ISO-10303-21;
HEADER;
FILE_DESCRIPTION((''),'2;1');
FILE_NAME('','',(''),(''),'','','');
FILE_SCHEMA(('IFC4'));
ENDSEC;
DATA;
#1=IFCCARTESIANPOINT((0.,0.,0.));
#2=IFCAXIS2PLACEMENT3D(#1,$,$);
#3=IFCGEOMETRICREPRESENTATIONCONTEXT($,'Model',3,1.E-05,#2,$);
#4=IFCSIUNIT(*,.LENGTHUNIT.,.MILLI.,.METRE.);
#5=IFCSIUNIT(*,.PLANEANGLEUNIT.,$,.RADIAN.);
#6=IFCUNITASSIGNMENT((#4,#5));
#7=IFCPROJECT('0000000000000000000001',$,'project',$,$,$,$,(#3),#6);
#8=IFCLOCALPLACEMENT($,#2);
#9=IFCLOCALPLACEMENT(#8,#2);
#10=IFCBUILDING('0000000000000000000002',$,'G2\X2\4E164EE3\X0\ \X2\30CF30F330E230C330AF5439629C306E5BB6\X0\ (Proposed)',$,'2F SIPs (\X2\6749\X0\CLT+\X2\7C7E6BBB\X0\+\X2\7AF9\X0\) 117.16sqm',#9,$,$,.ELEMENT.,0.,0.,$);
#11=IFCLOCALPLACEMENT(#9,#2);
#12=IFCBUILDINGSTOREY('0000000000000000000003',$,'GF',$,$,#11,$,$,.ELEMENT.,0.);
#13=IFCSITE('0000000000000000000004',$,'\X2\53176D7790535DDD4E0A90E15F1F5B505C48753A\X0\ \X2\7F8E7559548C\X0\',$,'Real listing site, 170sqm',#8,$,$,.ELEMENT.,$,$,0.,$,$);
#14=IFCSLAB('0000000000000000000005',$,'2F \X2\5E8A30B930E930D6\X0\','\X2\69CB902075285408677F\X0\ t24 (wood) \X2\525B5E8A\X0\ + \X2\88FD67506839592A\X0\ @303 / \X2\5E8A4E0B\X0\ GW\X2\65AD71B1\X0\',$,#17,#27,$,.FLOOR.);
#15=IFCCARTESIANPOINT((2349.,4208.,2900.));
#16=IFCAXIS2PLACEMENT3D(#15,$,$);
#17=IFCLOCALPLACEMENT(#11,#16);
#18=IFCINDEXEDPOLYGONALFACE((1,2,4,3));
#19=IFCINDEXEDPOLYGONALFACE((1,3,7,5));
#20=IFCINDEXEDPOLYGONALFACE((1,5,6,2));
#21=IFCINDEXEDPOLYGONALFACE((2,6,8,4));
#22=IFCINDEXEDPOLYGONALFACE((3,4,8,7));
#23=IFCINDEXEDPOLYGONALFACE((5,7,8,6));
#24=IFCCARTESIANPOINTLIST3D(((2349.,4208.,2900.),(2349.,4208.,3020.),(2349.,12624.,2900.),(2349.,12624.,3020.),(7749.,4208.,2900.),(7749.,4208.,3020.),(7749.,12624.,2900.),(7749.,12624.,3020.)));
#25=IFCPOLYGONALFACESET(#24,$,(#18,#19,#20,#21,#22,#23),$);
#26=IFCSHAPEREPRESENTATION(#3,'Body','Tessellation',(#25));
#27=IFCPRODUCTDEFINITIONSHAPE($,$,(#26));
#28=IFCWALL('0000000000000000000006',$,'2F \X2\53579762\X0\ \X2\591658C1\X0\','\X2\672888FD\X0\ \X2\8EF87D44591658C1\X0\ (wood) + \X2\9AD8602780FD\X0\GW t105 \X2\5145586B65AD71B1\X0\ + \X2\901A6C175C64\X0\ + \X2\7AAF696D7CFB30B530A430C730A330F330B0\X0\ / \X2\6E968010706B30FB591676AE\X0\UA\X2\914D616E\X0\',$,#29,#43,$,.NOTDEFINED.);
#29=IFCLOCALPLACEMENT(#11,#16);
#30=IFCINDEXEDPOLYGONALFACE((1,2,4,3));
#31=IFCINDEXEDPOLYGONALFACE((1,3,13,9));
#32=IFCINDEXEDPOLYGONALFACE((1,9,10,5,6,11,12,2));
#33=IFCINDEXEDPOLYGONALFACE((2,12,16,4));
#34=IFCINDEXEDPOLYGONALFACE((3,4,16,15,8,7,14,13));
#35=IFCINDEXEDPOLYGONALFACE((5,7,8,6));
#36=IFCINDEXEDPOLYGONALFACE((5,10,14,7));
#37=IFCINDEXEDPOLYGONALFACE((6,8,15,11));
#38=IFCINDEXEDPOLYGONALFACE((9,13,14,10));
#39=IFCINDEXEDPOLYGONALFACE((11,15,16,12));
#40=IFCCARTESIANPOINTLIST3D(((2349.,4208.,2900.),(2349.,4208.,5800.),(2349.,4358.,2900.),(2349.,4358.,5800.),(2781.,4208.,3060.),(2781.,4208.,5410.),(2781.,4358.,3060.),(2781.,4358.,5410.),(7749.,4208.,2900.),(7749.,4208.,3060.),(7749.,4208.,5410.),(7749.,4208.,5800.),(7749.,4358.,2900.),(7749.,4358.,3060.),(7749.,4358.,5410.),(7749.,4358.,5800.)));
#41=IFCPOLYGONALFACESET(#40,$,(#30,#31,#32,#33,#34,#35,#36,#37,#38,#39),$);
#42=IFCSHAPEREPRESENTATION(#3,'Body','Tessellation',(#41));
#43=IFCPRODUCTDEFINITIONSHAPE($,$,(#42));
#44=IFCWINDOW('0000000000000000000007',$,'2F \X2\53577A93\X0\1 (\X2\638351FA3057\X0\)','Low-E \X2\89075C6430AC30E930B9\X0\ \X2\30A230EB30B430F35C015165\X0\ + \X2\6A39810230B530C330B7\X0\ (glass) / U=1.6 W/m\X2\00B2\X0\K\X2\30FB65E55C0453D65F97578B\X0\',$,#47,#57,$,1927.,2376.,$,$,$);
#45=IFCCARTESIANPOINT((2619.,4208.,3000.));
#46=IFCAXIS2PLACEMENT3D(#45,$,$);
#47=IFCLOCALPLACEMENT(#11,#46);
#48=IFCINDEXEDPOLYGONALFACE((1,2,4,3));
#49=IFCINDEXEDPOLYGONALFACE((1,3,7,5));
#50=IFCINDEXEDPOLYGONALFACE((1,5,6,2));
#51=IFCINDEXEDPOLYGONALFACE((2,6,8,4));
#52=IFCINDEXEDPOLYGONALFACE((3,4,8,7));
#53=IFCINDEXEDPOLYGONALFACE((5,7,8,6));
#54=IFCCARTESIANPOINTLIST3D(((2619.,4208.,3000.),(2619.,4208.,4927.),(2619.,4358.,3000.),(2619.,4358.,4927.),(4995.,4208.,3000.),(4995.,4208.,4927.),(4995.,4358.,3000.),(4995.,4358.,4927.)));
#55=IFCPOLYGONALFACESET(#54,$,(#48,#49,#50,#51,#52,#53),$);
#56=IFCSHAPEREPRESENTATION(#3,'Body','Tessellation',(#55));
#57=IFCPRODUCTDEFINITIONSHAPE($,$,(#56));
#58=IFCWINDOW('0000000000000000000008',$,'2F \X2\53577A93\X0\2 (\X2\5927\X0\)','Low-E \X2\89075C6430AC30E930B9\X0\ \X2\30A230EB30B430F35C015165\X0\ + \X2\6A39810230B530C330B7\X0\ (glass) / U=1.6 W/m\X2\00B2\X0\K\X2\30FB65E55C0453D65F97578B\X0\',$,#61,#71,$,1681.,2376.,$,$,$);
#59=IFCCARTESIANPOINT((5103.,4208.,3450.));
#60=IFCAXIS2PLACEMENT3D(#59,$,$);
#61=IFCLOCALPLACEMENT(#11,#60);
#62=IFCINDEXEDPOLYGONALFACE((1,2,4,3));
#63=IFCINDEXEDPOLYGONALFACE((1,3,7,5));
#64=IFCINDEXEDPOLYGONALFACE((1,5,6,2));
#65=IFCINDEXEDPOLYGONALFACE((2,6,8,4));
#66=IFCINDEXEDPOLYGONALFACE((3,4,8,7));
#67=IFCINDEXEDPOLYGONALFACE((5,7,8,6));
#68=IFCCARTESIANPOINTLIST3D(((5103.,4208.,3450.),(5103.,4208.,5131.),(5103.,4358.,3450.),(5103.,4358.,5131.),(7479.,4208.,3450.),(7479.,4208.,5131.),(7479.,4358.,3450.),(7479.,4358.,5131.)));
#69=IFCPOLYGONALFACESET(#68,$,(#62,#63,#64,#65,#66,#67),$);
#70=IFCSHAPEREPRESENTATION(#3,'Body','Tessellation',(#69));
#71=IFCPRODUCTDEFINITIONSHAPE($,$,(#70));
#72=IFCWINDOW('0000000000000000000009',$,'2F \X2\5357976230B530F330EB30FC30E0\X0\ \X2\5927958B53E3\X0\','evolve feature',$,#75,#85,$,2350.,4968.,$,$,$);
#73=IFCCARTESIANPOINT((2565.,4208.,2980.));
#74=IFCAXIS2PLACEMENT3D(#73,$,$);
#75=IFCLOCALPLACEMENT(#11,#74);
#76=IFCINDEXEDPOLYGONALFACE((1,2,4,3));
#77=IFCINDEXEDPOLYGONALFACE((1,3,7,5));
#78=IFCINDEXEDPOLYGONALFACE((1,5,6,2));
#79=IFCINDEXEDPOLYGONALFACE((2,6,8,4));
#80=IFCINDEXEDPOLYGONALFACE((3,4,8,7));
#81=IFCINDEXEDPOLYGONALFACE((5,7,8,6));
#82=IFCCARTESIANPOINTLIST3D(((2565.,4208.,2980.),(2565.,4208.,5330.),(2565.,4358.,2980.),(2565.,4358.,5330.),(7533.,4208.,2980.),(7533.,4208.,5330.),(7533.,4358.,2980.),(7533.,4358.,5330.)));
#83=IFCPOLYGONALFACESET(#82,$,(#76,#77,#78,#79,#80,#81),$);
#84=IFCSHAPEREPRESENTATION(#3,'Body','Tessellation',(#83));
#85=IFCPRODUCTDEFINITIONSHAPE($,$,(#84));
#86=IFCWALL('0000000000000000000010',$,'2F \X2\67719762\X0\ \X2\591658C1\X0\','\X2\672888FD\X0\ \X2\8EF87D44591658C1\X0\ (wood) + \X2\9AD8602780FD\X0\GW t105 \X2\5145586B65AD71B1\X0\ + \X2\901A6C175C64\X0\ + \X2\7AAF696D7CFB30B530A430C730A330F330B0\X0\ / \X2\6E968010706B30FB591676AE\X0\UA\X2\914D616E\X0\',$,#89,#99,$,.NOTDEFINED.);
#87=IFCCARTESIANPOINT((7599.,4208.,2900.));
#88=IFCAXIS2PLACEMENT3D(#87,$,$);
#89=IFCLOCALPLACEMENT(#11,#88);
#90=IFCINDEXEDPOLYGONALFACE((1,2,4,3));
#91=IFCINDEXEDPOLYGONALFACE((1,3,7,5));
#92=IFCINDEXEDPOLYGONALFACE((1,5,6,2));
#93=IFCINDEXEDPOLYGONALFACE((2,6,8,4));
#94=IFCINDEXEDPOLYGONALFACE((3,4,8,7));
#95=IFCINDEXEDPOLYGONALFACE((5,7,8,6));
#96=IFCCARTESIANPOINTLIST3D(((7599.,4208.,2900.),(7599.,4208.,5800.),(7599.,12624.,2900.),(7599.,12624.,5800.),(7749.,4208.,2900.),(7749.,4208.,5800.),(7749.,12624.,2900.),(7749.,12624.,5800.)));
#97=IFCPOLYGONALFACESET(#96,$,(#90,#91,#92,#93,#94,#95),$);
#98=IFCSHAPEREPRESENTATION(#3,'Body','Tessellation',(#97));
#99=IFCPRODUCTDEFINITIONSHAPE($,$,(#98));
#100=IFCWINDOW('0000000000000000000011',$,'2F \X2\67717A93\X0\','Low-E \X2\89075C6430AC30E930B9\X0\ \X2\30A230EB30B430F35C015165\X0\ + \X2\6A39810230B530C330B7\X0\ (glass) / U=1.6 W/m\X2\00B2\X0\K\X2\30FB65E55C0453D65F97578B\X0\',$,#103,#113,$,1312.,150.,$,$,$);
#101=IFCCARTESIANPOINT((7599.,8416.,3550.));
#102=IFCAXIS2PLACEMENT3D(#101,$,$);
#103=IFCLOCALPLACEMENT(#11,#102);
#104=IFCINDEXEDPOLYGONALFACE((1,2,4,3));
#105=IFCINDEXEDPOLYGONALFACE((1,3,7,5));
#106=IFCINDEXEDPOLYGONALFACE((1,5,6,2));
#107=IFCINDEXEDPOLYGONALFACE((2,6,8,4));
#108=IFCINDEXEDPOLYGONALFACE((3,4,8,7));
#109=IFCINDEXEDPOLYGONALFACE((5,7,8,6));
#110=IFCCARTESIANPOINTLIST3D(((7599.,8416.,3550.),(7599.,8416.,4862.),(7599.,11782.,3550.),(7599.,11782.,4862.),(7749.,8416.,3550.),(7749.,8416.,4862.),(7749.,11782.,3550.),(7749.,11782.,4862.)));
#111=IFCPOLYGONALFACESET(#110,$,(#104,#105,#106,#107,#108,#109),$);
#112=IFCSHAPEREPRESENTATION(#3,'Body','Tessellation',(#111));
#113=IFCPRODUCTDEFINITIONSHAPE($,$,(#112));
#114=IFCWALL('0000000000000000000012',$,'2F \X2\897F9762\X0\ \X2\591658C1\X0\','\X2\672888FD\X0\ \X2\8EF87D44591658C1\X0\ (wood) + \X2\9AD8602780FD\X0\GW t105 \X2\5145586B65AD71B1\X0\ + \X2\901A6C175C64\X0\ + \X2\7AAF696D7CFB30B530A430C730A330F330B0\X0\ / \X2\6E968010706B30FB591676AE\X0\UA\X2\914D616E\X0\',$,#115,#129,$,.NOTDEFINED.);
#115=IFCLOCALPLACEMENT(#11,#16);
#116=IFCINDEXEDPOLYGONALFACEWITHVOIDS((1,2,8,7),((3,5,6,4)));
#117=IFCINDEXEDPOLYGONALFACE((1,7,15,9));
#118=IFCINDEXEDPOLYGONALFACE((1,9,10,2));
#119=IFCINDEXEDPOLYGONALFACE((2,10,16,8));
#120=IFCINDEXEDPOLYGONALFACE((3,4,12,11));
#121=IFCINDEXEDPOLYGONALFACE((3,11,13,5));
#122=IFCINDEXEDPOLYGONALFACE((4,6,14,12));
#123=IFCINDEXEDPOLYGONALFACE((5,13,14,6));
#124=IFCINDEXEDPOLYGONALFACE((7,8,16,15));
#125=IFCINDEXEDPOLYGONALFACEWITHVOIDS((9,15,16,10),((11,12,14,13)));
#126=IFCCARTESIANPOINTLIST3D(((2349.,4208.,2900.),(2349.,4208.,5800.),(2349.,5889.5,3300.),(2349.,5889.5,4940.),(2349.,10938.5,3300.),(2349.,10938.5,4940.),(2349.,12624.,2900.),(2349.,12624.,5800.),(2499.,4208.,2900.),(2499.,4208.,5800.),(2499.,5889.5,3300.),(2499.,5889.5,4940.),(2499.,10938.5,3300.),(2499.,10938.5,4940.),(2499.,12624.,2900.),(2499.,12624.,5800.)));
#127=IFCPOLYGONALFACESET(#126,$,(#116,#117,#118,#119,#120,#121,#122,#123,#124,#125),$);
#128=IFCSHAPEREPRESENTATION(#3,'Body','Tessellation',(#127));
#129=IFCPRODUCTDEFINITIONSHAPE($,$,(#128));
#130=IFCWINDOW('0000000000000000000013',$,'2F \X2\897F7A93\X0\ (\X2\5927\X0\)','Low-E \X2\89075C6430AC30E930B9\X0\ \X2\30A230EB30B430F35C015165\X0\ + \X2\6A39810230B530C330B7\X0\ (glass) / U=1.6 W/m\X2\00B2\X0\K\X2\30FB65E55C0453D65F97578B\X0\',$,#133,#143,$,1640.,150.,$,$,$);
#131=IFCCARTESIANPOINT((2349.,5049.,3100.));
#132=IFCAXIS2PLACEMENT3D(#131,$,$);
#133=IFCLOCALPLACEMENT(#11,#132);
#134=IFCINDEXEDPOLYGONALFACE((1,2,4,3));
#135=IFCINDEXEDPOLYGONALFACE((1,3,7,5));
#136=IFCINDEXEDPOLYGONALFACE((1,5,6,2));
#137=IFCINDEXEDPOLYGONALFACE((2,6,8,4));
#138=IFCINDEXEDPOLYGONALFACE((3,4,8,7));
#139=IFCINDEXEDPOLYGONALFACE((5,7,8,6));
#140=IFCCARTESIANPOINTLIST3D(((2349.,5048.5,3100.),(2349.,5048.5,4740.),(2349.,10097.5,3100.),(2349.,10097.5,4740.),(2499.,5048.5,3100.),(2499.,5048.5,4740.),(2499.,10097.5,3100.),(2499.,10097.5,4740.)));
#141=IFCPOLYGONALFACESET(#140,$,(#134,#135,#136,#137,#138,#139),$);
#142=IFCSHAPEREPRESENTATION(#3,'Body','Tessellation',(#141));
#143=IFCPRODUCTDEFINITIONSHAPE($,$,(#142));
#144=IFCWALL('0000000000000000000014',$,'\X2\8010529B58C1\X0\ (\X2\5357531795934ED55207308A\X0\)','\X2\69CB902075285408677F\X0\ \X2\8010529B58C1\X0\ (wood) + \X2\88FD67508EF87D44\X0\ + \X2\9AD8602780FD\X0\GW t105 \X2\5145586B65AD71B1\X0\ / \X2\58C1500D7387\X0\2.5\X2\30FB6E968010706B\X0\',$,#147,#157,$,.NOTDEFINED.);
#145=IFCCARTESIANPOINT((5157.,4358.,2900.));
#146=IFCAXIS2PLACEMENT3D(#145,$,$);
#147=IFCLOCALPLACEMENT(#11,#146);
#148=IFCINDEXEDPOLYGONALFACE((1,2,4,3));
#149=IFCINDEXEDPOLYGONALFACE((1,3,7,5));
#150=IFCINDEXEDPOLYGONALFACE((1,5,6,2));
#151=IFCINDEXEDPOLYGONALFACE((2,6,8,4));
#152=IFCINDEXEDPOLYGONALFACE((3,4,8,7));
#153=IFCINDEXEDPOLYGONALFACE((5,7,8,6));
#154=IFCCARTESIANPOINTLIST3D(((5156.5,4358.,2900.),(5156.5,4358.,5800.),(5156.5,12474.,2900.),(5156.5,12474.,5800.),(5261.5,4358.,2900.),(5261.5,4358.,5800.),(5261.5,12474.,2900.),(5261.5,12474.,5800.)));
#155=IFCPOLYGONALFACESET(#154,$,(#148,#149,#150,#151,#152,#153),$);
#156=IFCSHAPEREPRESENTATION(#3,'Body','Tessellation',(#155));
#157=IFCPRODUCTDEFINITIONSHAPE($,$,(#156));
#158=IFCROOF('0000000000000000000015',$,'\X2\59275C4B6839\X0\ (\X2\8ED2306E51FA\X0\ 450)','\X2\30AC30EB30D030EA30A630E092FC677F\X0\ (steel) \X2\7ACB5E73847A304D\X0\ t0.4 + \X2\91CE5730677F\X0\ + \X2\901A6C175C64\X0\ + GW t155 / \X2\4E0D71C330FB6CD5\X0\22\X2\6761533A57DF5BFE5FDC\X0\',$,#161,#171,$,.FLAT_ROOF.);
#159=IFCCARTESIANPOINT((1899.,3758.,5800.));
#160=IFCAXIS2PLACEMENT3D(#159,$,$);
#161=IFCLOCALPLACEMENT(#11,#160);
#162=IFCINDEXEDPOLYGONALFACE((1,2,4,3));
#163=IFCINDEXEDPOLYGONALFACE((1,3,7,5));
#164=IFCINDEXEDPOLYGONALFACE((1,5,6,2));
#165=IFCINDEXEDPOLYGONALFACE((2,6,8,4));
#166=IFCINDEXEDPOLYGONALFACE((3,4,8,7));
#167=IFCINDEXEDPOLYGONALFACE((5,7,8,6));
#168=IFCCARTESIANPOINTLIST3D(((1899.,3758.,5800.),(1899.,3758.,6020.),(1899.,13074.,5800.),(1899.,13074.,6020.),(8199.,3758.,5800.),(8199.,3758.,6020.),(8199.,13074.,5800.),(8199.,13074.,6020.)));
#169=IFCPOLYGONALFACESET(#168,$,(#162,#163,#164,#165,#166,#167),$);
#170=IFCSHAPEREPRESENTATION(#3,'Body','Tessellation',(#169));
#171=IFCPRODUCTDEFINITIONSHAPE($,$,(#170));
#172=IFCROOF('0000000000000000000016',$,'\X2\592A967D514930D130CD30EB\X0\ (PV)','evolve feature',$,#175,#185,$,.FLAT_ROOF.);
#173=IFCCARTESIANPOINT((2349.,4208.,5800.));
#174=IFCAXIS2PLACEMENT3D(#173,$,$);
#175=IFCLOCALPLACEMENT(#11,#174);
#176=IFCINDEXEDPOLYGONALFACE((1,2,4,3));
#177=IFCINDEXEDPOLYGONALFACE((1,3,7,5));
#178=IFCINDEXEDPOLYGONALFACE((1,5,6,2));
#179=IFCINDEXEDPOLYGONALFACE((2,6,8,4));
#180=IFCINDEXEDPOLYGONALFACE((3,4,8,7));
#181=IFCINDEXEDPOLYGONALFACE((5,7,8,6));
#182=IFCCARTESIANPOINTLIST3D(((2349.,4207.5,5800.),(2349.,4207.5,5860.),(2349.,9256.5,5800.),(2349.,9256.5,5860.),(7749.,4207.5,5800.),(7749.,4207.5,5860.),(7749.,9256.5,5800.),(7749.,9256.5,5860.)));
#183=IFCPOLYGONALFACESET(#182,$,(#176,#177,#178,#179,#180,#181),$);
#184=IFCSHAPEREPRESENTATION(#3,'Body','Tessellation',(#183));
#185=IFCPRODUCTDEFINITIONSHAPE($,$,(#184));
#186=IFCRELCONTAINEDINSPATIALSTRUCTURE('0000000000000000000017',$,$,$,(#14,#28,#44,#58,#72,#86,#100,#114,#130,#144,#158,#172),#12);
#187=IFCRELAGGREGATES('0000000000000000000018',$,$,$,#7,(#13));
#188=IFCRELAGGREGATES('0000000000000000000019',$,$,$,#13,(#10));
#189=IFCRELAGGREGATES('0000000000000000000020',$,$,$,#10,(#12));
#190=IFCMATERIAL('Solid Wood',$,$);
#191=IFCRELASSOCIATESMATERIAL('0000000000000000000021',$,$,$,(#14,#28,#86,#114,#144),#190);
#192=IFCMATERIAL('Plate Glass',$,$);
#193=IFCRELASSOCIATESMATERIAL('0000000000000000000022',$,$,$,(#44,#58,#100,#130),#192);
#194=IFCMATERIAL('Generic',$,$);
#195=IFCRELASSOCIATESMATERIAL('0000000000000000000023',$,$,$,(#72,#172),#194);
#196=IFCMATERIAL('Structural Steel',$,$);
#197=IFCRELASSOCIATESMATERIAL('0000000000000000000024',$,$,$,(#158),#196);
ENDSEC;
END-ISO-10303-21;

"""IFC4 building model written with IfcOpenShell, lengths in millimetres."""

from ifc_helpers import new_model, si_unit, frame, frame_2d, origin, place, context, project, spatial, rectangle, extrude, material, element, fill, save


model = new_model("IFC4")

# Units and contexts
model_context = context("Model", 3, precision=1e-05, world=origin())
ifc_project = project(units=[si_unit("LENGTHUNIT", "METRE", prefix="MILLI"), si_unit("PLANEANGLEUNIT", "RADIAN")], contexts=[model_context])

# Site, building, storey
site_placement = place(None, origin())
site = spatial("IfcSite", under=ifc_project, at=site_placement, Name="北海道川上郡弟子屈町 美留和", ObjectType="Real listing site, 170sqm", CompositionType="ELEMENT", RefElevation=0.0)
building_placement = place(site_placement, origin())
building = spatial("IfcBuilding", under=site, at=building_placement, Name="G2世代 ハンモック吹抜の家 (Proposed)", ObjectType="2F SIPs (杉CLT+籾殻+竹) 117.16sqm", CompositionType="ELEMENT", ElevationOfRefHeight=0.0, ElevationOfTerrain=0.0)
storey_placement = place(building_placement, origin())
storey = spatial("IfcBuildingStorey", under=building, at=storey_placement, Name="GF", CompositionType="ELEMENT", Elevation=0.0)

# Slab
ifc_material_1 = material(Name="Solid Wood")
slab_placement = place(storey_placement, frame((2349.0, 4208.0, 2900.0)))
element("IfcSlab", 1, at=slab_placement, inside=storey, material=ifc_material_1, Name="2F 床スラブ", Description="構造用合板 t24 (wood) 剛床 + 製材根太 @303 / 床下 GW断熱", PredefinedType="FLOOR", context=model_context, shape_type="SweptSolid", body=[
    extrude(rectangle(XDim=5400.0, YDim=8416.0, at=frame_2d((2700.0, 4208.0))), frame((2349.0, 4208.0, 2900.0)), (0.0, 0.0, 1.0), 120.0),
])

# Wall, openings, windows
wall_1_placement = place(storey_placement, frame((2349.0, 4208.0, 2900.0)))
wall_1 = element("IfcWall", 2, at=wall_1_placement, inside=storey, material=ifc_material_1, Name="2F 南面 外壁", Description="木製 軸組外壁 (wood) + 高性能GW t105 充填断熱 + 通気層 + 窯業系サイディング / 準耐火・外皮UA配慮", PredefinedType="NOTDEFINED", context=model_context, shape_type="SweptSolid", body=[
    extrude(rectangle(XDim=5400.0, YDim=150.0, at=frame_2d((2700.0, 75.0))), frame((2349.0, 4208.0, 2900.0)), (0.0, 0.0, 1.0), 2900.0),
])
opening_1_placement = place(storey_placement, frame((2619.0, 4208.0, 3000.0)))
opening_1 = element("IfcOpeningElement", 3, at=opening_1_placement, cuts=wall_1, PredefinedType="NOTDEFINED", context=model_context, shape_type="SweptSolid", body=[
    extrude(rectangle(XDim=2376.0, YDim=150.0, at=frame_2d((1188.0, 75.0))), frame((2619.0, 4208.0, 3000.0)), (0.0, 0.0, 1.0), 1927.0),
])
opening_2_placement = place(storey_placement, frame((5103.0, 4208.0, 3450.0)))
opening_2 = element("IfcOpeningElement", 4, at=opening_2_placement, cuts=wall_1, PredefinedType="NOTDEFINED", context=model_context, shape_type="SweptSolid", body=[
    extrude(rectangle(XDim=2376.0, YDim=150.0, at=frame_2d((1188.0, 75.0))), frame((5103.0, 4208.0, 3450.0)), (0.0, 0.0, 1.0), 1681.0),
])
opening_3_placement = place(storey_placement, frame((2565.0, 4208.0, 2980.0)))
opening_3 = element("IfcOpeningElement", 5, at=opening_3_placement, cuts=wall_1, PredefinedType="NOTDEFINED", context=model_context, shape_type="SweptSolid", body=[
    extrude(rectangle(XDim=4968.0, YDim=150.0, at=frame_2d((2484.0, 75.0))), frame((2565.0, 4208.0, 2980.0)), (0.0, 0.0, 1.0), 2350.0),
])
ifc_material_2 = material(Name="Plate Glass")
window_1_placement = place(storey_placement, frame((2619.0, 4208.0, 3000.0)))
window_1 = element("IfcWindow", 6, at=window_1_placement, inside=storey, material=ifc_material_2, Name="2F 南窓1 (掃出し)", Description="Low-E 複層ガラス アルゴン封入 + 樹脂サッシ (glass) / U=1.6 W/m²K・日射取得型", OverallHeight=1927.0, OverallWidth=2376.0, context=model_context, shape_type="SweptSolid", body=[
    extrude(rectangle(XDim=2376.0, YDim=150.0, at=frame_2d((1188.0, 75.0))), frame((2619.0, 4208.0, 3000.0)), (0.0, 0.0, 1.0), 1927.0),
])
fill(opening_1, window_1)
window_2_placement = place(storey_placement, frame((5103.0, 4208.0, 3450.0)))
window_2 = element("IfcWindow", 7, at=window_2_placement, inside=storey, material=ifc_material_2, Name="2F 南窓2 (大)", Description="Low-E 複層ガラス アルゴン封入 + 樹脂サッシ (glass) / U=1.6 W/m²K・日射取得型", OverallHeight=1681.0, OverallWidth=2376.0, context=model_context, shape_type="SweptSolid", body=[
    extrude(rectangle(XDim=2376.0, YDim=150.0, at=frame_2d((1188.0, 75.0))), frame((5103.0, 4208.0, 3450.0)), (0.0, 0.0, 1.0), 1681.0),
])
fill(opening_2, window_2)
ifc_material_3 = material(Name="Generic")
window_3_placement = place(storey_placement, frame((2565.0, 4208.0, 2980.0)))
window_3 = element("IfcWindow", 8, at=window_3_placement, inside=storey, material=ifc_material_3, Name="2F 南面サンルーム 大開口", Description="evolve feature", OverallHeight=2350.0, OverallWidth=4968.0, context=model_context, shape_type="SweptSolid", body=[
    extrude(rectangle(XDim=4968.0, YDim=150.0, at=frame_2d((2484.0, 75.0))), frame((2565.0, 4208.0, 2980.0)), (0.0, 0.0, 1.0), 2350.0),
])
fill(opening_3, window_3)

# Walls, openings, windows
wall_2_placement = place(storey_placement, frame((7599.0, 4208.0, 2900.0)))
wall_2 = element("IfcWall", 9, at=wall_2_placement, inside=storey, material=ifc_material_1, Name="2F 東面 外壁", Description="木製 軸組外壁 (wood) + 高性能GW t105 充填断熱 + 通気層 + 窯業系サイディング / 準耐火・外皮UA配慮", PredefinedType="NOTDEFINED", context=model_context, shape_type="SweptSolid", body=[
    extrude(rectangle(XDim=150.0, YDim=8416.0, at=frame_2d((75.0, 4208.0))), frame((7599.0, 4208.0, 2900.0)), (0.0, 0.0, 1.0), 2900.0),
])
opening_4_placement = place(storey_placement, frame((7599.0, 8416.0, 3550.0)))
opening_4 = element("IfcOpeningElement", 10, at=opening_4_placement, cuts=wall_2, PredefinedType="NOTDEFINED", context=model_context, shape_type="SweptSolid", body=[
    extrude(rectangle(XDim=150.0, YDim=3366.0, at=frame_2d((75.0, 1683.0))), frame((7599.0, 8416.0, 3550.0)), (0.0, 0.0, 1.0), 1312.0),
])
window_4_placement = place(storey_placement, frame((7599.0, 8416.0, 3550.0)))
window_4 = element("IfcWindow", 11, at=window_4_placement, inside=storey, material=ifc_material_2, Name="2F 東窓", Description="Low-E 複層ガラス アルゴン封入 + 樹脂サッシ (glass) / U=1.6 W/m²K・日射取得型", OverallHeight=1312.0, OverallWidth=150.0, context=model_context, shape_type="SweptSolid", body=[
    extrude(rectangle(XDim=150.0, YDim=3366.0, at=frame_2d((75.0, 1683.0))), frame((7599.0, 8416.0, 3550.0)), (0.0, 0.0, 1.0), 1312.0),
])
fill(opening_4, window_4)
wall_3_placement = place(storey_placement, frame((2349.0, 4208.0, 2900.0)))
wall_3 = element("IfcWall", 12, at=wall_3_placement, inside=storey, material=ifc_material_1, Name="2F 西面 外壁", Description="木製 軸組外壁 (wood) + 高性能GW t105 充填断熱 + 通気層 + 窯業系サイディング / 準耐火・外皮UA配慮", PredefinedType="NOTDEFINED", context=model_context, shape_type="SweptSolid", body=[
    extrude(rectangle(XDim=150.0, YDim=8416.0, at=frame_2d((75.0, 4208.0))), frame((2349.0, 4208.0, 2900.0)), (0.0, 0.0, 1.0), 2900.0),
])
opening_5_placement = place(storey_placement, frame((2349.0, 5049.0, 3100.0)))
opening_5 = element("IfcOpeningElement", 13, at=opening_5_placement, cuts=wall_3, PredefinedType="NOTDEFINED", context=model_context, shape_type="SweptSolid", body=[
    extrude(rectangle(XDim=150.0, YDim=5049.0, at=frame_2d((75.0, 2524.0))), frame((2349.0, 5049.0, 3100.0)), (0.0, 0.0, 1.0), 1640.0),
])
window_5_placement = place(storey_placement, frame((2349.0, 5049.0, 3100.0)))
window_5 = element("IfcWindow", 14, at=window_5_placement, inside=storey, material=ifc_material_2, Name="2F 西窓 (大)", Description="Low-E 複層ガラス アルゴン封入 + 樹脂サッシ (glass) / U=1.6 W/m²K・日射取得型", OverallHeight=1640.0, OverallWidth=150.0, context=model_context, shape_type="SweptSolid", body=[
    extrude(rectangle(XDim=150.0, YDim=5049.0, at=frame_2d((75.0, 2524.0))), frame((2349.0, 5049.0, 3100.0)), (0.0, 0.0, 1.0), 1640.0),
])
fill(opening_5, window_5)

# Wall
wall_4_placement = place(storey_placement, frame((5157.0, 4358.0, 2900.0)))
element("IfcWall", 15, at=wall_4_placement, inside=storey, material=ifc_material_1, Name="耐力壁 (南北間仕切り)", Description="構造用合板 耐力壁 (wood) + 製材軸組 + 高性能GW t105 充填断熱 / 壁倍率2.5・準耐火", PredefinedType="NOTDEFINED", context=model_context, shape_type="SweptSolid", body=[
    extrude(rectangle(XDim=105.0, YDim=8116.0, at=frame_2d((52.0, 4058.0))), frame((5157.0, 4358.0, 2900.0)), (0.0, 0.0, 1.0), 2900.0),
])

# Roofs
ifc_material_4 = material(Name="Structural Steel")
roof_1_placement = place(storey_placement, frame((1899.0, 3758.0, 5800.0)))
element("IfcRoof", 16, at=roof_1_placement, inside=storey, material=ifc_material_4, Name="大屋根 (軒の出 450)", Description="ガルバリウム鋼板 (steel) 立平葺き t0.4 + 野地板 + 通気層 + GW t155 / 不燃・法22条区域対応", PredefinedType="FLAT_ROOF", context=model_context, shape_type="SweptSolid", body=[
    extrude(rectangle(XDim=6300.0, YDim=9316.0, at=frame_2d((3150.0, 4658.0))), frame((1899.0, 3758.0, 5800.0)), (0.0, 0.0, 1.0), 220.0),
])
roof_2_placement = place(storey_placement, frame((2349.0, 4208.0, 5800.0)))
element("IfcRoof", 17, at=roof_2_placement, inside=storey, material=ifc_material_3, Name="太陽光パネル (PV)", Description="evolve feature", PredefinedType="FLAT_ROOF", context=model_context, shape_type="SweptSolid", body=[
    extrude(rectangle(XDim=5400.0, YDim=5049.0, at=frame_2d((2700.0, 2524.0))), frame((2349.0, 4208.0, 5800.0)), (0.0, 0.0, 1.0), 60.0),
])

save(model, "model.ifc")
